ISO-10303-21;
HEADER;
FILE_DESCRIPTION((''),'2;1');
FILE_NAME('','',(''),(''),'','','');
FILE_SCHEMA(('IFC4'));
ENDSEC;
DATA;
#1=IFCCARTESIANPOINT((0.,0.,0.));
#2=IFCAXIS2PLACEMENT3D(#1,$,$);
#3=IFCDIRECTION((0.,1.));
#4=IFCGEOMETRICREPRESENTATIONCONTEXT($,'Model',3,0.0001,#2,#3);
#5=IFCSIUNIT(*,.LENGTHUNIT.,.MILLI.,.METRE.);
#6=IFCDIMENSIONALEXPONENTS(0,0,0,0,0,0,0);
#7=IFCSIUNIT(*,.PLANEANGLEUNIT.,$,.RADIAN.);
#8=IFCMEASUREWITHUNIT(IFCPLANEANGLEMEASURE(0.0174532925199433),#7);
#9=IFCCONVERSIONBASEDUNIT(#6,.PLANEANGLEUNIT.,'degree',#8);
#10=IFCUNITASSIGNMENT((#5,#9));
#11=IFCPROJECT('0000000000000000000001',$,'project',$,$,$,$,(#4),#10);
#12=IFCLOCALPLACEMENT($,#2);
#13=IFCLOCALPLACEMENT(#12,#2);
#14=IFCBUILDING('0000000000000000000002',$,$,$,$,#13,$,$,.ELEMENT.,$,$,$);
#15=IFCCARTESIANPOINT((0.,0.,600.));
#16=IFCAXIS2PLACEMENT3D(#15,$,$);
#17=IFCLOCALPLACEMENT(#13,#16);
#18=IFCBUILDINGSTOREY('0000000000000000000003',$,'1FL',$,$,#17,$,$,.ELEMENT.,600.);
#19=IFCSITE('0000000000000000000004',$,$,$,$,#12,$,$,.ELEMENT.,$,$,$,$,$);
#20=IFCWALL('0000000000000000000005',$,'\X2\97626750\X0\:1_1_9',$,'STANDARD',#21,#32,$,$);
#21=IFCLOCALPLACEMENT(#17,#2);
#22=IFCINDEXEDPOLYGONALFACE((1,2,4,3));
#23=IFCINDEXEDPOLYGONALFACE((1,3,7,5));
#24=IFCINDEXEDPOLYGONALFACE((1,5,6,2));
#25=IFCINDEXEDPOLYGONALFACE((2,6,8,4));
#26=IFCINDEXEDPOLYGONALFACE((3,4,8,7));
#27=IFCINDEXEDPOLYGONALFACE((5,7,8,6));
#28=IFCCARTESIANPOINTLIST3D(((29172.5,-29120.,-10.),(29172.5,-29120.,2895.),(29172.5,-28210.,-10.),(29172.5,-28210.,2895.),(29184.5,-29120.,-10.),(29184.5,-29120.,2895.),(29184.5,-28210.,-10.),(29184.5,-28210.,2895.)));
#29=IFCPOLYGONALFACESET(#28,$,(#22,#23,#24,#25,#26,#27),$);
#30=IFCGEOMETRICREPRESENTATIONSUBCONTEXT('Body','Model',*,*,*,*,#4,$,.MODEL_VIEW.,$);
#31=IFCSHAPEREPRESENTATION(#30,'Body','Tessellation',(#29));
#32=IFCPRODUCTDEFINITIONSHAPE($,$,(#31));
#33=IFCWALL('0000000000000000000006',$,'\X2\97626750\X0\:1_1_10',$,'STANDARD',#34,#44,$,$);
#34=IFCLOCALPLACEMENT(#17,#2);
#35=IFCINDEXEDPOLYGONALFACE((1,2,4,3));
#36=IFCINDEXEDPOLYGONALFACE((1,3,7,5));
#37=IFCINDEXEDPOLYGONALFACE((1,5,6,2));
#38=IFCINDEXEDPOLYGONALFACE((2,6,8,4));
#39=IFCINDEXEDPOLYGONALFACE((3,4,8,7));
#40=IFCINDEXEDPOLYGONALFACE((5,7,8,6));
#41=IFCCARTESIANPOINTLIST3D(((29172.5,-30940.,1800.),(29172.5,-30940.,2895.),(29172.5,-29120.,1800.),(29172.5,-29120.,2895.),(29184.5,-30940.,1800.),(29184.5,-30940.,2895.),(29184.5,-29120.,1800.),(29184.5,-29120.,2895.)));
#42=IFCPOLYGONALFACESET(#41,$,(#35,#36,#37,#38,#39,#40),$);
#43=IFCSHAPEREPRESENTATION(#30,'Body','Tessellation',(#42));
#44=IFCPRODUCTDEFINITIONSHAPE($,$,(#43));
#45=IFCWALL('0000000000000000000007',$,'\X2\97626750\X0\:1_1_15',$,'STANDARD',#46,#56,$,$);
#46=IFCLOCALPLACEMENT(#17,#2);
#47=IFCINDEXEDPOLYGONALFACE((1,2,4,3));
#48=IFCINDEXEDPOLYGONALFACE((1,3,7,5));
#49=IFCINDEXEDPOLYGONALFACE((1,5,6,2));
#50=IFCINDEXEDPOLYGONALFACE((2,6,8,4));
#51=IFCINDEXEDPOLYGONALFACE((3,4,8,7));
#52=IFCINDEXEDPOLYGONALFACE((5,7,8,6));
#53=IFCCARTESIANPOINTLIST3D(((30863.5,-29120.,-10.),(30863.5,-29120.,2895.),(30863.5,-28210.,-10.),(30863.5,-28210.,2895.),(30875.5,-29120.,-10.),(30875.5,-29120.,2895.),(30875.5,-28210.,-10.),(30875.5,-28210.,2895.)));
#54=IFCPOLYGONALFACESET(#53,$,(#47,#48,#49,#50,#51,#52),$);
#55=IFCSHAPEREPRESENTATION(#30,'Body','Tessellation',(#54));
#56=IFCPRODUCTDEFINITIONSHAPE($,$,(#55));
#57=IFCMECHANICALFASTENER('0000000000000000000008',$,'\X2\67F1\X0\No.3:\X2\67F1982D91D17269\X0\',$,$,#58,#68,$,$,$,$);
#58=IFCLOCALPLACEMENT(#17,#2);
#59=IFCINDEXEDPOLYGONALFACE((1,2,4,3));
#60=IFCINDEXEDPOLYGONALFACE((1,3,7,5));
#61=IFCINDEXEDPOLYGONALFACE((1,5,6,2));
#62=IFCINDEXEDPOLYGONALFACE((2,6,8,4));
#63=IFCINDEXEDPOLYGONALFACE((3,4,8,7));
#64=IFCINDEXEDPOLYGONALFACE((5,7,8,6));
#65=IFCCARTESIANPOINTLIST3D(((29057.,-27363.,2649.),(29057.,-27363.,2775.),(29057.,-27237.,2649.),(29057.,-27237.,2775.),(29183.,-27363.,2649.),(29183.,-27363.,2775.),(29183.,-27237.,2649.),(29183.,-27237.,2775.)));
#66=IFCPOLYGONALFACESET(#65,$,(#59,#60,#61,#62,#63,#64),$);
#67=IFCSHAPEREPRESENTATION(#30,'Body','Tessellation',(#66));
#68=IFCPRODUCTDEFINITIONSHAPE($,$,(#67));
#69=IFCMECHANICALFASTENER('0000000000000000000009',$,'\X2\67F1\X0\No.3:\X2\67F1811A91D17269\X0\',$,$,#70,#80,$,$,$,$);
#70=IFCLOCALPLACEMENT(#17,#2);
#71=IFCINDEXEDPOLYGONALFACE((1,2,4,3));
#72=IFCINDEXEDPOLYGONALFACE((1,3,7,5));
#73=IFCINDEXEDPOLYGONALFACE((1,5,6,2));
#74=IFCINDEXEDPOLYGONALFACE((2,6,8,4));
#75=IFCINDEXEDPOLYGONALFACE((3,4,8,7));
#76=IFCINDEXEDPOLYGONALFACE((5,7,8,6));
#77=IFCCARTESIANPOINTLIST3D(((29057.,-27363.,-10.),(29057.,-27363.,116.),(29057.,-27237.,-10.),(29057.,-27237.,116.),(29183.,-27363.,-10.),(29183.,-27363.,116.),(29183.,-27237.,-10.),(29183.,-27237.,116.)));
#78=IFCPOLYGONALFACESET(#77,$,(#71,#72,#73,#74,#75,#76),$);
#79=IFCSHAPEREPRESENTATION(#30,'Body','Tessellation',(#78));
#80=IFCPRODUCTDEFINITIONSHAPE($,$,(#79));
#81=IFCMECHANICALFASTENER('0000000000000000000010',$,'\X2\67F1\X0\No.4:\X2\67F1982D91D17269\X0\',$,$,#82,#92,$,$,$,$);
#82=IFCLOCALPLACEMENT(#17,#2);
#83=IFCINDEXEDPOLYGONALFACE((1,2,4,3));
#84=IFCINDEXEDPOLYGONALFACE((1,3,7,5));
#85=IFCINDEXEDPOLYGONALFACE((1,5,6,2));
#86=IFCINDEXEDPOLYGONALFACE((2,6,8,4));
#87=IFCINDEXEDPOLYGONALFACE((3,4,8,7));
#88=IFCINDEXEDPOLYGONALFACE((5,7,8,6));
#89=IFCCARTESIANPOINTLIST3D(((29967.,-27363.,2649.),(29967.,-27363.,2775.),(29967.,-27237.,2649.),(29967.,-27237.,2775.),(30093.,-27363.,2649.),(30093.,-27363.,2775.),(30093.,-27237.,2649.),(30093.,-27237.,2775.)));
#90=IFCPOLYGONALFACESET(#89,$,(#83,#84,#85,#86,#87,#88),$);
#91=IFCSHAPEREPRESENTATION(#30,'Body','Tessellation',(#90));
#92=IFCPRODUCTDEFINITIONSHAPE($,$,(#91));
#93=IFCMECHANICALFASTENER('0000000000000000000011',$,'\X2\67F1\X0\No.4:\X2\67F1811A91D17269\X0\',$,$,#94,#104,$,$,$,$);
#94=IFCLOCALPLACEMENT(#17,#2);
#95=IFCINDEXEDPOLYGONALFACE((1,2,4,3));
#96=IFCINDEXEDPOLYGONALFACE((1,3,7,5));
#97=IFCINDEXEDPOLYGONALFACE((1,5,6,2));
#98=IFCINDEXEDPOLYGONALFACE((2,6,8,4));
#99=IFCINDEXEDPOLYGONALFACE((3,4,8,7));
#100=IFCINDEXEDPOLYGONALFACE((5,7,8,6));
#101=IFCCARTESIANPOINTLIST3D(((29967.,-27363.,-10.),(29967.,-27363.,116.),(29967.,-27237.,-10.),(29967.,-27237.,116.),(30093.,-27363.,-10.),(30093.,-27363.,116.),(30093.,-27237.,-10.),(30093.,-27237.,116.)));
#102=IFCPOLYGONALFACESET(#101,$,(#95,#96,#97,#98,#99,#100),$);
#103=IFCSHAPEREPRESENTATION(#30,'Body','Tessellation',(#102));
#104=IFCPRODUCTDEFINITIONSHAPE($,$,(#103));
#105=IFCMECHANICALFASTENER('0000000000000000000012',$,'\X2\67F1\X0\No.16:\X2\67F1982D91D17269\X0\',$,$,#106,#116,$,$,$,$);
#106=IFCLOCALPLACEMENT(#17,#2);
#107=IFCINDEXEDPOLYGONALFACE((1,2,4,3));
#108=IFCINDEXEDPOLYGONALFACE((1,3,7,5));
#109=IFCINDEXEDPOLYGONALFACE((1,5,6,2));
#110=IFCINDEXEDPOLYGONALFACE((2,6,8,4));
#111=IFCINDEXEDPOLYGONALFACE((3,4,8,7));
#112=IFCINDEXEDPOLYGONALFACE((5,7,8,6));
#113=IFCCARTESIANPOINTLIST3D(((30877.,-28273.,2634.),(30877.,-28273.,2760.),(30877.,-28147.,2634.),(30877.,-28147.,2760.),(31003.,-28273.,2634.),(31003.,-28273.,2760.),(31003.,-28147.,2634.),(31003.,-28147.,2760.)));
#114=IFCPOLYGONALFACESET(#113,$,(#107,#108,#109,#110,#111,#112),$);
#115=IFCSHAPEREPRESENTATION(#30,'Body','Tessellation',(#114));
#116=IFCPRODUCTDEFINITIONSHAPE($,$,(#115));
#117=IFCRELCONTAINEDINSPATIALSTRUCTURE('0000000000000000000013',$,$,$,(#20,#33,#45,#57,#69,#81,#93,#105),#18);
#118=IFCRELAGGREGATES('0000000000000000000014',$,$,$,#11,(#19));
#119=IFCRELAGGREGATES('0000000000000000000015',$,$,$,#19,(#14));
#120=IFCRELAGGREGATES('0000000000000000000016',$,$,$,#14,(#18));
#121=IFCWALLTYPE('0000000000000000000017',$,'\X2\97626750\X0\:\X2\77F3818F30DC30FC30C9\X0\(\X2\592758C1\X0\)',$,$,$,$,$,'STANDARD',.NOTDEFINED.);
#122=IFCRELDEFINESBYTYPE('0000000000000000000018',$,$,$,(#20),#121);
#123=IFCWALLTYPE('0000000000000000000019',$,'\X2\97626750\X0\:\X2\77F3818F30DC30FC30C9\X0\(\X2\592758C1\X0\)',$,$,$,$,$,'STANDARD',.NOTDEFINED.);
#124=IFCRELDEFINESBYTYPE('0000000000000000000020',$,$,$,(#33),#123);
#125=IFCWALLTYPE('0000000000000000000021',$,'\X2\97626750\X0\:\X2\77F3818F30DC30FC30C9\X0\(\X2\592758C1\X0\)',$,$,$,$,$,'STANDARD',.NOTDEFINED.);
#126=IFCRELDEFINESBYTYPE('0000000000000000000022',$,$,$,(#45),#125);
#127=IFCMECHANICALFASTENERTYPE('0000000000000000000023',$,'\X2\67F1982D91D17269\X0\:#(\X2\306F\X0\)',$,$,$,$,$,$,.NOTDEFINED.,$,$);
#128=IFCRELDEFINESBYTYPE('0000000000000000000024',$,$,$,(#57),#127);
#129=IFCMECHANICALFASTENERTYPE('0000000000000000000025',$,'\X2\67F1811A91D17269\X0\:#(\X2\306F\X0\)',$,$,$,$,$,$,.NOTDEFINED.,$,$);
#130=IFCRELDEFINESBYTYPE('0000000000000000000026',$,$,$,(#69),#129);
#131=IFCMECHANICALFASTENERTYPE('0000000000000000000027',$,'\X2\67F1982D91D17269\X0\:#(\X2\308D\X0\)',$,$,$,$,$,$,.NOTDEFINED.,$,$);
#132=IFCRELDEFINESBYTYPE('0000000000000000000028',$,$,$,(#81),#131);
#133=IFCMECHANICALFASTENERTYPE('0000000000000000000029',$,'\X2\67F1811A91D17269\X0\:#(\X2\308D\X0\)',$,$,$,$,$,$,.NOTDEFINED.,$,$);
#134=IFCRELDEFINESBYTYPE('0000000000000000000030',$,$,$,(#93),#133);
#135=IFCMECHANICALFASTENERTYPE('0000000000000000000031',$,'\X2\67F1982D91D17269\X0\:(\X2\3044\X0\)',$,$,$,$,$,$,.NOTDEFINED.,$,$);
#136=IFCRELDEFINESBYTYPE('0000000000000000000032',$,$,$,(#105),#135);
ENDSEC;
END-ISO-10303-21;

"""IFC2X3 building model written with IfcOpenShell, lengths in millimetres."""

from ifc_helpers import new_model, entity, si_unit, converted_unit, direction, frame, origin, origin_with_axes, origin_2d, place, context, subcontext, project, spatial, polyline, rectangle, outline, extrude, type_object, element, save


model = new_model("IFC2X3")

# Units and contexts
model_context = context("Model", 3, precision=0.0001, world=origin(), true_north=direction((0.0, 1.0)))
body_context = subcontext(model_context, "Body", "Model", "MODEL_VIEW")
ifc_project = project(units=[si_unit("LENGTHUNIT", "METRE", prefix="MILLI"), converted_unit("PLANEANGLEUNIT", "degree", entity("IfcPlaneAngleMeasure", 0.0174532925199433), si_unit("PLANEANGLEUNIT", "RADIAN"), dimensions=[0, 0, 0, 0, 0, 0, 0])], contexts=[model_context])

# Site, building, storey
site_placement = place(None, origin())
site = spatial("IfcSite", under=ifc_project, at=site_placement, CompositionType="ELEMENT")
building_placement = place(site_placement, origin())
building = spatial("IfcBuilding", under=site, at=building_placement, CompositionType="ELEMENT")
storey_placement = place(building_placement, frame((0.0, 0.0, 600.0)))
storey = spatial("IfcBuildingStorey", under=building, at=storey_placement, Name="1FL", CompositionType="ELEMENT", Elevation=600.0)

# Walls
wall_type_1 = type_object("IfcWallType", Name="面材:石膏ボード(大壁)", ElementType="STANDARD", PredefinedType="NOTDEFINED")
wall_1_placement = place(storey_placement, frame((29184.5, -28665.0, -10.0), z_axis=(-1.0, 0.0, 0.0), x_axis=(0.0, -1.0, 0.0)))
element("IfcWall", 1, at=wall_1_placement, inside=storey, type_object=wall_type_1, Name="面材:1_1_9", ObjectType="STANDARD", context=body_context, shape_type="SweptSolid", body=[
    extrude(outline(polyline([(455.0, 0.0, 0.0), (-455.0, 0.0, 0.0), (-455.0, 2905.0, 0.0), (455.0, 2905.0, 0.0), (455.0, 0.0, 0.0)])), origin_with_axes(), (0.0, 0.0, 1.0), 12.0),
])
wall_type_2 = type_object("IfcWallType", Name="面材:石膏ボード(大壁)", ElementType="STANDARD", PredefinedType="NOTDEFINED")
wall_2_placement = place(storey_placement, frame((29184.5, -30030.0, 1800.0), z_axis=(-1.0, 0.0, 0.0), x_axis=(0.0, -1.0, 0.0)))
element("IfcWall", 2, at=wall_2_placement, inside=storey, type_object=wall_type_2, Name="面材:1_1_10", ObjectType="STANDARD", context=body_context, shape_type="SweptSolid", body=[
    extrude(outline(polyline([(-910.0, 0.0, 0.0), (-910.0, 1095.0, 0.0), (910.0, 1095.0, 0.0), (910.0, 0.0, 0.0), (-910.0, 0.0, 0.0)])), origin_with_axes(), (0.0, 0.0, 1.0), 12.0),
])
wall_type_3 = type_object("IfcWallType", Name="面材:石膏ボード(大壁)", ElementType="STANDARD", PredefinedType="NOTDEFINED")
wall_3_placement = place(storey_placement, frame((30875.5, -28665.0, -10.0), z_axis=(-1.0, 0.0, 0.0), x_axis=(0.0, -1.0, 0.0)))
element("IfcWall", 3, at=wall_3_placement, inside=storey, type_object=wall_type_3, Name="面材:1_1_15", ObjectType="STANDARD", context=body_context, shape_type="SweptSolid", body=[
    extrude(outline(polyline([(455.0, 0.0, 0.0), (-455.0, 0.0, 0.0), (-455.0, 2905.0, 0.0), (455.0, 2905.0, 0.0), (455.0, 0.0, 0.0)])), origin_with_axes(), (0.0, 0.0, 1.0), 12.0),
])

# Mechanical fasteners
mechanical_fastener_type_1 = type_object("IfcMechanicalFastenerType", Name="柱頭金物:#(は)")
mechanical_fastener_1_placement = place(storey_placement, frame((29120.0, -27300.0, 2649.0)))
element("IfcMechanicalFastener", 4, at=mechanical_fastener_1_placement, inside=storey, type_object=mechanical_fastener_type_1, Name="柱No.3:柱頭金物", context=body_context, shape_type="SweptSolid", body=[
    extrude(rectangle(XDim=126.0, YDim=126.0, at=origin_2d()), origin_with_axes(), (0.0, 0.0, 1.0), 126.0),
])
mechanical_fastener_type_2 = type_object("IfcMechanicalFastenerType", Name="柱脚金物:#(は)")
mechanical_fastener_2_placement = place(storey_placement, frame((29120.0, -27300.0, -10.0)))
element("IfcMechanicalFastener", 5, at=mechanical_fastener_2_placement, inside=storey, type_object=mechanical_fastener_type_2, Name="柱No.3:柱脚金物", context=body_context, shape_type="SweptSolid", body=[
    extrude(rectangle(XDim=126.0, YDim=126.0, at=origin_2d()), origin_with_axes(), (0.0, 0.0, 1.0), 126.0),
])
mechanical_fastener_type_3 = type_object("IfcMechanicalFastenerType", Name="柱頭金物:#(ろ)")
mechanical_fastener_3_placement = place(storey_placement, frame((30030.0, -27300.0, 2649.0)))
element("IfcMechanicalFastener", 6, at=mechanical_fastener_3_placement, inside=storey, type_object=mechanical_fastener_type_3, Name="柱No.4:柱頭金物", context=body_context, shape_type="SweptSolid", body=[
    extrude(rectangle(XDim=126.0, YDim=126.0, at=origin_2d()), origin_with_axes(), (0.0, 0.0, 1.0), 126.0),
])
mechanical_fastener_type_4 = type_object("IfcMechanicalFastenerType", Name="柱脚金物:#(ろ)")
mechanical_fastener_4_placement = place(storey_placement, frame((30030.0, -27300.0, -10.0)))
element("IfcMechanicalFastener", 7, at=mechanical_fastener_4_placement, inside=storey, type_object=mechanical_fastener_type_4, Name="柱No.4:柱脚金物", context=body_context, shape_type="SweptSolid", body=[
    extrude(rectangle(XDim=126.0, YDim=126.0, at=origin_2d()), origin_with_axes(), (0.0, 0.0, 1.0), 126.0),
])
mechanical_fastener_type_5 = type_object("IfcMechanicalFastenerType", Name="柱頭金物:(い)")
mechanical_fastener_5_placement = place(storey_placement, frame((30940.0, -28210.0, 2634.0)))
element("IfcMechanicalFastener", 8, at=mechanical_fastener_5_placement, inside=storey, type_object=mechanical_fastener_type_5, Name="柱No.16:柱頭金物", context=body_context, shape_type="SweptSolid", body=[
    extrude(rectangle(XDim=126.0, YDim=126.0, at=origin_2d()), origin_with_axes(), (0.0, 0.0, 1.0), 126.0),
])

save(model, "model.ifc")
